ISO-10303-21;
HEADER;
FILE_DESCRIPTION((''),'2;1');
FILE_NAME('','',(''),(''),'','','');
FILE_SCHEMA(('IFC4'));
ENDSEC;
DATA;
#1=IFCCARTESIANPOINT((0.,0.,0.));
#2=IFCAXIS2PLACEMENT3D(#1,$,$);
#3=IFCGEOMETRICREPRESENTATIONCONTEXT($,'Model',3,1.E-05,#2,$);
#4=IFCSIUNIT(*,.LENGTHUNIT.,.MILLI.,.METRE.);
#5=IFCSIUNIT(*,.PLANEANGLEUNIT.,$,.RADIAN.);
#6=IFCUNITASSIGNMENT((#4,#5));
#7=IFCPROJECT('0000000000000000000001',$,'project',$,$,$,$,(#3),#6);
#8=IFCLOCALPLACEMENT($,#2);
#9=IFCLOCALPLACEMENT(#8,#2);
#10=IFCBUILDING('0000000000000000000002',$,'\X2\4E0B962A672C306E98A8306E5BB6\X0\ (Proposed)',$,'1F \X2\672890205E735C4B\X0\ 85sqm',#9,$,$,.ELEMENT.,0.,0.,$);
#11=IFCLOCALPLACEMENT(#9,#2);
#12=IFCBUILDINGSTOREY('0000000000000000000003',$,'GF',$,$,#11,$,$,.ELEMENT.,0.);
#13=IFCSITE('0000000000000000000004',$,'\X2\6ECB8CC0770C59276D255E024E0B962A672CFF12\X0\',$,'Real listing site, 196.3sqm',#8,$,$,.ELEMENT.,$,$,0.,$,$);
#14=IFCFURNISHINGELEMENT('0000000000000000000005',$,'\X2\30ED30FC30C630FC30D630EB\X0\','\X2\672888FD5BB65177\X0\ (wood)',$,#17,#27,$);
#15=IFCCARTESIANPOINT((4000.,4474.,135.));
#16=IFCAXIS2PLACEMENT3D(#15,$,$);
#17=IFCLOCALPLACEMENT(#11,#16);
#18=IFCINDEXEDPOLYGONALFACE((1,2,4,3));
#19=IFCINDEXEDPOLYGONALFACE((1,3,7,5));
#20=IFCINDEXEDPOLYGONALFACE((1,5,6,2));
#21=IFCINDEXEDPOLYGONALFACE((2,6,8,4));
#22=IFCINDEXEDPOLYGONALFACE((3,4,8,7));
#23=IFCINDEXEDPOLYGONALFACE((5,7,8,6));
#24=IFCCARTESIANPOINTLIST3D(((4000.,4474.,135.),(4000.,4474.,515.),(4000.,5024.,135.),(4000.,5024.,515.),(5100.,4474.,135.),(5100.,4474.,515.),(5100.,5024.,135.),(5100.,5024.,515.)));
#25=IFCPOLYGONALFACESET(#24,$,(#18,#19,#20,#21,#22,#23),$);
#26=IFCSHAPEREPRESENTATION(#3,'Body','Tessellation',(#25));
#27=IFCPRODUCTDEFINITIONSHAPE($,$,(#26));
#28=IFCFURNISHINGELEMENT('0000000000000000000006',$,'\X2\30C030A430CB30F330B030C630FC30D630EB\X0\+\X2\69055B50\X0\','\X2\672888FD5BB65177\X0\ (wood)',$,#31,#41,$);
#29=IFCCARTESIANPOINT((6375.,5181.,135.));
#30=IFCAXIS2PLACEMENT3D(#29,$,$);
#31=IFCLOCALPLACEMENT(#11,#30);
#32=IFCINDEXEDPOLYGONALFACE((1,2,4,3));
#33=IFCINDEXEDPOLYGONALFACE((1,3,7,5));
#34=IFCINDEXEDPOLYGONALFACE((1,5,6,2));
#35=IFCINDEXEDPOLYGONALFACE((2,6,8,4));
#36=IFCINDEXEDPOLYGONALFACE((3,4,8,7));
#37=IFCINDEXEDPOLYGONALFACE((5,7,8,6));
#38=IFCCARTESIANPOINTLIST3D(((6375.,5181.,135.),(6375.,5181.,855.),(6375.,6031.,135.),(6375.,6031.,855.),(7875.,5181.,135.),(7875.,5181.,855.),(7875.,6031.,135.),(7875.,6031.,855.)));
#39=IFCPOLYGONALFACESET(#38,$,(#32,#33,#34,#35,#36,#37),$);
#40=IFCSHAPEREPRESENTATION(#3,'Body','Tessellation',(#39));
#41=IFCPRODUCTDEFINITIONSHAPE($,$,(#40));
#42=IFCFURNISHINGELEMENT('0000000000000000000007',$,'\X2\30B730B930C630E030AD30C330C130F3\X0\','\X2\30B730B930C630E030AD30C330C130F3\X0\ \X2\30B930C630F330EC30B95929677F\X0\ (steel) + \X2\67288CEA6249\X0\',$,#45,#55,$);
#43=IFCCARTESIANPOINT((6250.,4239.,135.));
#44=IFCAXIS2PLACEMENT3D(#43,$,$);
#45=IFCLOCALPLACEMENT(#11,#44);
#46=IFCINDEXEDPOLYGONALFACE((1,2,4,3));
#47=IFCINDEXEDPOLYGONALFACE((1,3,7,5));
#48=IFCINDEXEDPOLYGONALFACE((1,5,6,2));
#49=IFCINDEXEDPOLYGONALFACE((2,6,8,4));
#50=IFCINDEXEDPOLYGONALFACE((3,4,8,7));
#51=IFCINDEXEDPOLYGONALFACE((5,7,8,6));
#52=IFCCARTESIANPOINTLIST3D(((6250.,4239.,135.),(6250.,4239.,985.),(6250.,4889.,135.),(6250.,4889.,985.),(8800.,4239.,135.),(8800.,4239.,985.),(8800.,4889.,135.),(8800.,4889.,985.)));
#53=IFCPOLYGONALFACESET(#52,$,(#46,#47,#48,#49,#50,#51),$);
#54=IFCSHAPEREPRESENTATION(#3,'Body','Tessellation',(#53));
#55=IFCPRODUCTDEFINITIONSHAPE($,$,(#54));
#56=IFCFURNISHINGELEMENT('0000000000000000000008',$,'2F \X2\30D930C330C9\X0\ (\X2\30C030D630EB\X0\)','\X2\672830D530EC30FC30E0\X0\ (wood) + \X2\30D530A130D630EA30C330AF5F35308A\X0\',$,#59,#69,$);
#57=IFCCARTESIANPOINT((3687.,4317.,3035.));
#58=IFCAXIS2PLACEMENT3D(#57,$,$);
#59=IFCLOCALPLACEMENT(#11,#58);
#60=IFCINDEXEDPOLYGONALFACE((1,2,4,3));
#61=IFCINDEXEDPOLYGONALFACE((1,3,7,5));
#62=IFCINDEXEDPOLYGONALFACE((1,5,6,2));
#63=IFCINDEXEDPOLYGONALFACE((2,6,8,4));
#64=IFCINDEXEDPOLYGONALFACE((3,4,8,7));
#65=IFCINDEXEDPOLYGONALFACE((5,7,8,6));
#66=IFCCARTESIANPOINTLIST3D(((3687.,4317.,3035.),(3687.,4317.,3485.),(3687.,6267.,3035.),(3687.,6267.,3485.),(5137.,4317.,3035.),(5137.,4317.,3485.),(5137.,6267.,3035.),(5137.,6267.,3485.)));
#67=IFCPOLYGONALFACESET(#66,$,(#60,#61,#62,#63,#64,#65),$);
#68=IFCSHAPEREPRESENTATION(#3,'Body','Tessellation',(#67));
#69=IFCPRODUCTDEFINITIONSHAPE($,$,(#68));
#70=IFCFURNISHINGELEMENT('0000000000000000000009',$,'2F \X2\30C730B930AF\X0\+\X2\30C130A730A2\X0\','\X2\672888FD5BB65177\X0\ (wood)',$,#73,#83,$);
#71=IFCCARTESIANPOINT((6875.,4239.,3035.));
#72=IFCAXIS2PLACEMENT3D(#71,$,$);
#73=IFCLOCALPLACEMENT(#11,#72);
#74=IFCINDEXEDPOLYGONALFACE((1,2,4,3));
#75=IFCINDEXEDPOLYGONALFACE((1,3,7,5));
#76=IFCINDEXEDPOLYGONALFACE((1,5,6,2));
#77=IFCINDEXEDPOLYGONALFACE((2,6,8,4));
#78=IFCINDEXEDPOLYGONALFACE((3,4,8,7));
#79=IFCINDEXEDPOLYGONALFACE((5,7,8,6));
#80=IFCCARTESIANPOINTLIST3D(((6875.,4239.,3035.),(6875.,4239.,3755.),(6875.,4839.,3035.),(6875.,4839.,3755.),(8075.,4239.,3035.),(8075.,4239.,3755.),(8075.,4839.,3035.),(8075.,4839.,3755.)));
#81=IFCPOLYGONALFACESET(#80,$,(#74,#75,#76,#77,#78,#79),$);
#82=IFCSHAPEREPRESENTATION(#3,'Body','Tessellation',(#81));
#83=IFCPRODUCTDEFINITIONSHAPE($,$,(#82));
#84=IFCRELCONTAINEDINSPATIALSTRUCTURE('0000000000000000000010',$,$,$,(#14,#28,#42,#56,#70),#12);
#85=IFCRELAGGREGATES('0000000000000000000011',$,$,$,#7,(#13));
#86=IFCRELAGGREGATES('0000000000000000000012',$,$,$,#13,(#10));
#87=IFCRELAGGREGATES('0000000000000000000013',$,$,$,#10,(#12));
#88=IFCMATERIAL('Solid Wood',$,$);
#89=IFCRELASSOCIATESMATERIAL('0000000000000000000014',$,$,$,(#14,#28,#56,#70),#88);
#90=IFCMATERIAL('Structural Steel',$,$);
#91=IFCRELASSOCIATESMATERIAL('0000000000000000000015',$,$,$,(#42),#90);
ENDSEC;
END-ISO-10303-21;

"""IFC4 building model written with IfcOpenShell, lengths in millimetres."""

from ifc_helpers import new_model, si_unit, frame, frame_2d, origin, place, context, project, spatial, rectangle, extrude, material, element, save


model = new_model("IFC4")

# Units and contexts
model_context = context("Model", 3, precision=1e-05, world=origin())
ifc_project = project(units=[si_unit("LENGTHUNIT", "METRE", prefix="MILLI"), si_unit("PLANEANGLEUNIT", "RADIAN")], contexts=[model_context])

# Site, building, storey
site_placement = place(None, origin())
site = spatial("IfcSite", under=ifc_project, at=site_placement, Name="滋賀県大津市下阪本２", ObjectType="Real listing site, 196.3sqm", CompositionType="ELEMENT", RefElevation=0.0)
building_placement = place(site_placement, origin())
building = spatial("IfcBuilding", under=site, at=building_placement, Name="下阪本の風の家 (Proposed)", ObjectType="1F 木造平屋 85sqm", CompositionType="ELEMENT", ElevationOfRefHeight=0.0, ElevationOfTerrain=0.0)
storey_placement = place(building_placement, origin())
storey = spatial("IfcBuildingStorey", under=building, at=storey_placement, Name="GF", CompositionType="ELEMENT", Elevation=0.0)

# Shared definitions
ifc_material_1 = material(Name="Solid Wood")

# Shared definitions
ifc_material_2 = material(Name="Structural Steel")

# Furnishing elements
furnishing_1_placement = place(storey_placement, frame((4000.0, 4474.0, 135.0)))
element("IfcFurnishingElement", 1, at=furnishing_1_placement, inside=storey, material=ifc_material_1, Name="ローテーブル", Description="木製家具 (wood)", context=model_context, shape_type="SweptSolid", body=[
    extrude(rectangle(XDim=1100.0, YDim=550.0, at=frame_2d((550.0, 275.0))), frame((4000.0, 4474.0, 135.0)), (0.0, 0.0, 1.0), 380.0),
])
furnishing_2_placement = place(storey_placement, frame((6375.0, 5181.0, 135.0)))
element("IfcFurnishingElement", 2, at=furnishing_2_placement, inside=storey, material=ifc_material_1, Name="ダイニングテーブル+椅子", Description="木製家具 (wood)", context=model_context, shape_type="SweptSolid", body=[
    extrude(rectangle(XDim=1500.0, YDim=850.0, at=frame_2d((750.0, 425.0))), frame((6375.0, 5181.0, 135.0)), (0.0, 0.0, 1.0), 720.0),
])
furnishing_3_placement = place(storey_placement, frame((6250.0, 4239.0, 135.0)))
element("IfcFurnishingElement", 3, at=furnishing_3_placement, inside=storey, material=ifc_material_2, Name="システムキッチン", Description="システムキッチン ステンレス天板 (steel) + 木質扉", context=model_context, shape_type="SweptSolid", body=[
    extrude(rectangle(XDim=2550.0, YDim=650.0, at=frame_2d((1275.0, 325.0))), frame((6250.0, 4239.0, 135.0)), (0.0, 0.0, 1.0), 850.0),
])
furnishing_4_placement = place(storey_placement, frame((3687.0, 4317.0, 3035.0)))
element("IfcFurnishingElement", 4, at=furnishing_4_placement, inside=storey, material=ifc_material_1, Name="2F ベッド (ダブル)", Description="木フレーム (wood) + ファブリック張り", context=model_context, shape_type="SweptSolid", body=[
    extrude(rectangle(XDim=1450.0, YDim=1950.0, at=frame_2d((725.0, 975.0))), frame((3687.0, 4317.0, 3035.0)), (0.0, 0.0, 1.0), 450.0),
])
furnishing_5_placement = place(storey_placement, frame((6875.0, 4239.0, 3035.0)))
element("IfcFurnishingElement", 5, at=furnishing_5_placement, inside=storey, material=ifc_material_1, Name="2F デスク+チェア", Description="木製家具 (wood)", context=model_context, shape_type="SweptSolid", body=[
    extrude(rectangle(XDim=1200.0, YDim=600.0, at=frame_2d((600.0, 300.0))), frame((6875.0, 4239.0, 3035.0)), (0.0, 0.0, 1.0), 720.0),
])

save(model, "model.ifc")
